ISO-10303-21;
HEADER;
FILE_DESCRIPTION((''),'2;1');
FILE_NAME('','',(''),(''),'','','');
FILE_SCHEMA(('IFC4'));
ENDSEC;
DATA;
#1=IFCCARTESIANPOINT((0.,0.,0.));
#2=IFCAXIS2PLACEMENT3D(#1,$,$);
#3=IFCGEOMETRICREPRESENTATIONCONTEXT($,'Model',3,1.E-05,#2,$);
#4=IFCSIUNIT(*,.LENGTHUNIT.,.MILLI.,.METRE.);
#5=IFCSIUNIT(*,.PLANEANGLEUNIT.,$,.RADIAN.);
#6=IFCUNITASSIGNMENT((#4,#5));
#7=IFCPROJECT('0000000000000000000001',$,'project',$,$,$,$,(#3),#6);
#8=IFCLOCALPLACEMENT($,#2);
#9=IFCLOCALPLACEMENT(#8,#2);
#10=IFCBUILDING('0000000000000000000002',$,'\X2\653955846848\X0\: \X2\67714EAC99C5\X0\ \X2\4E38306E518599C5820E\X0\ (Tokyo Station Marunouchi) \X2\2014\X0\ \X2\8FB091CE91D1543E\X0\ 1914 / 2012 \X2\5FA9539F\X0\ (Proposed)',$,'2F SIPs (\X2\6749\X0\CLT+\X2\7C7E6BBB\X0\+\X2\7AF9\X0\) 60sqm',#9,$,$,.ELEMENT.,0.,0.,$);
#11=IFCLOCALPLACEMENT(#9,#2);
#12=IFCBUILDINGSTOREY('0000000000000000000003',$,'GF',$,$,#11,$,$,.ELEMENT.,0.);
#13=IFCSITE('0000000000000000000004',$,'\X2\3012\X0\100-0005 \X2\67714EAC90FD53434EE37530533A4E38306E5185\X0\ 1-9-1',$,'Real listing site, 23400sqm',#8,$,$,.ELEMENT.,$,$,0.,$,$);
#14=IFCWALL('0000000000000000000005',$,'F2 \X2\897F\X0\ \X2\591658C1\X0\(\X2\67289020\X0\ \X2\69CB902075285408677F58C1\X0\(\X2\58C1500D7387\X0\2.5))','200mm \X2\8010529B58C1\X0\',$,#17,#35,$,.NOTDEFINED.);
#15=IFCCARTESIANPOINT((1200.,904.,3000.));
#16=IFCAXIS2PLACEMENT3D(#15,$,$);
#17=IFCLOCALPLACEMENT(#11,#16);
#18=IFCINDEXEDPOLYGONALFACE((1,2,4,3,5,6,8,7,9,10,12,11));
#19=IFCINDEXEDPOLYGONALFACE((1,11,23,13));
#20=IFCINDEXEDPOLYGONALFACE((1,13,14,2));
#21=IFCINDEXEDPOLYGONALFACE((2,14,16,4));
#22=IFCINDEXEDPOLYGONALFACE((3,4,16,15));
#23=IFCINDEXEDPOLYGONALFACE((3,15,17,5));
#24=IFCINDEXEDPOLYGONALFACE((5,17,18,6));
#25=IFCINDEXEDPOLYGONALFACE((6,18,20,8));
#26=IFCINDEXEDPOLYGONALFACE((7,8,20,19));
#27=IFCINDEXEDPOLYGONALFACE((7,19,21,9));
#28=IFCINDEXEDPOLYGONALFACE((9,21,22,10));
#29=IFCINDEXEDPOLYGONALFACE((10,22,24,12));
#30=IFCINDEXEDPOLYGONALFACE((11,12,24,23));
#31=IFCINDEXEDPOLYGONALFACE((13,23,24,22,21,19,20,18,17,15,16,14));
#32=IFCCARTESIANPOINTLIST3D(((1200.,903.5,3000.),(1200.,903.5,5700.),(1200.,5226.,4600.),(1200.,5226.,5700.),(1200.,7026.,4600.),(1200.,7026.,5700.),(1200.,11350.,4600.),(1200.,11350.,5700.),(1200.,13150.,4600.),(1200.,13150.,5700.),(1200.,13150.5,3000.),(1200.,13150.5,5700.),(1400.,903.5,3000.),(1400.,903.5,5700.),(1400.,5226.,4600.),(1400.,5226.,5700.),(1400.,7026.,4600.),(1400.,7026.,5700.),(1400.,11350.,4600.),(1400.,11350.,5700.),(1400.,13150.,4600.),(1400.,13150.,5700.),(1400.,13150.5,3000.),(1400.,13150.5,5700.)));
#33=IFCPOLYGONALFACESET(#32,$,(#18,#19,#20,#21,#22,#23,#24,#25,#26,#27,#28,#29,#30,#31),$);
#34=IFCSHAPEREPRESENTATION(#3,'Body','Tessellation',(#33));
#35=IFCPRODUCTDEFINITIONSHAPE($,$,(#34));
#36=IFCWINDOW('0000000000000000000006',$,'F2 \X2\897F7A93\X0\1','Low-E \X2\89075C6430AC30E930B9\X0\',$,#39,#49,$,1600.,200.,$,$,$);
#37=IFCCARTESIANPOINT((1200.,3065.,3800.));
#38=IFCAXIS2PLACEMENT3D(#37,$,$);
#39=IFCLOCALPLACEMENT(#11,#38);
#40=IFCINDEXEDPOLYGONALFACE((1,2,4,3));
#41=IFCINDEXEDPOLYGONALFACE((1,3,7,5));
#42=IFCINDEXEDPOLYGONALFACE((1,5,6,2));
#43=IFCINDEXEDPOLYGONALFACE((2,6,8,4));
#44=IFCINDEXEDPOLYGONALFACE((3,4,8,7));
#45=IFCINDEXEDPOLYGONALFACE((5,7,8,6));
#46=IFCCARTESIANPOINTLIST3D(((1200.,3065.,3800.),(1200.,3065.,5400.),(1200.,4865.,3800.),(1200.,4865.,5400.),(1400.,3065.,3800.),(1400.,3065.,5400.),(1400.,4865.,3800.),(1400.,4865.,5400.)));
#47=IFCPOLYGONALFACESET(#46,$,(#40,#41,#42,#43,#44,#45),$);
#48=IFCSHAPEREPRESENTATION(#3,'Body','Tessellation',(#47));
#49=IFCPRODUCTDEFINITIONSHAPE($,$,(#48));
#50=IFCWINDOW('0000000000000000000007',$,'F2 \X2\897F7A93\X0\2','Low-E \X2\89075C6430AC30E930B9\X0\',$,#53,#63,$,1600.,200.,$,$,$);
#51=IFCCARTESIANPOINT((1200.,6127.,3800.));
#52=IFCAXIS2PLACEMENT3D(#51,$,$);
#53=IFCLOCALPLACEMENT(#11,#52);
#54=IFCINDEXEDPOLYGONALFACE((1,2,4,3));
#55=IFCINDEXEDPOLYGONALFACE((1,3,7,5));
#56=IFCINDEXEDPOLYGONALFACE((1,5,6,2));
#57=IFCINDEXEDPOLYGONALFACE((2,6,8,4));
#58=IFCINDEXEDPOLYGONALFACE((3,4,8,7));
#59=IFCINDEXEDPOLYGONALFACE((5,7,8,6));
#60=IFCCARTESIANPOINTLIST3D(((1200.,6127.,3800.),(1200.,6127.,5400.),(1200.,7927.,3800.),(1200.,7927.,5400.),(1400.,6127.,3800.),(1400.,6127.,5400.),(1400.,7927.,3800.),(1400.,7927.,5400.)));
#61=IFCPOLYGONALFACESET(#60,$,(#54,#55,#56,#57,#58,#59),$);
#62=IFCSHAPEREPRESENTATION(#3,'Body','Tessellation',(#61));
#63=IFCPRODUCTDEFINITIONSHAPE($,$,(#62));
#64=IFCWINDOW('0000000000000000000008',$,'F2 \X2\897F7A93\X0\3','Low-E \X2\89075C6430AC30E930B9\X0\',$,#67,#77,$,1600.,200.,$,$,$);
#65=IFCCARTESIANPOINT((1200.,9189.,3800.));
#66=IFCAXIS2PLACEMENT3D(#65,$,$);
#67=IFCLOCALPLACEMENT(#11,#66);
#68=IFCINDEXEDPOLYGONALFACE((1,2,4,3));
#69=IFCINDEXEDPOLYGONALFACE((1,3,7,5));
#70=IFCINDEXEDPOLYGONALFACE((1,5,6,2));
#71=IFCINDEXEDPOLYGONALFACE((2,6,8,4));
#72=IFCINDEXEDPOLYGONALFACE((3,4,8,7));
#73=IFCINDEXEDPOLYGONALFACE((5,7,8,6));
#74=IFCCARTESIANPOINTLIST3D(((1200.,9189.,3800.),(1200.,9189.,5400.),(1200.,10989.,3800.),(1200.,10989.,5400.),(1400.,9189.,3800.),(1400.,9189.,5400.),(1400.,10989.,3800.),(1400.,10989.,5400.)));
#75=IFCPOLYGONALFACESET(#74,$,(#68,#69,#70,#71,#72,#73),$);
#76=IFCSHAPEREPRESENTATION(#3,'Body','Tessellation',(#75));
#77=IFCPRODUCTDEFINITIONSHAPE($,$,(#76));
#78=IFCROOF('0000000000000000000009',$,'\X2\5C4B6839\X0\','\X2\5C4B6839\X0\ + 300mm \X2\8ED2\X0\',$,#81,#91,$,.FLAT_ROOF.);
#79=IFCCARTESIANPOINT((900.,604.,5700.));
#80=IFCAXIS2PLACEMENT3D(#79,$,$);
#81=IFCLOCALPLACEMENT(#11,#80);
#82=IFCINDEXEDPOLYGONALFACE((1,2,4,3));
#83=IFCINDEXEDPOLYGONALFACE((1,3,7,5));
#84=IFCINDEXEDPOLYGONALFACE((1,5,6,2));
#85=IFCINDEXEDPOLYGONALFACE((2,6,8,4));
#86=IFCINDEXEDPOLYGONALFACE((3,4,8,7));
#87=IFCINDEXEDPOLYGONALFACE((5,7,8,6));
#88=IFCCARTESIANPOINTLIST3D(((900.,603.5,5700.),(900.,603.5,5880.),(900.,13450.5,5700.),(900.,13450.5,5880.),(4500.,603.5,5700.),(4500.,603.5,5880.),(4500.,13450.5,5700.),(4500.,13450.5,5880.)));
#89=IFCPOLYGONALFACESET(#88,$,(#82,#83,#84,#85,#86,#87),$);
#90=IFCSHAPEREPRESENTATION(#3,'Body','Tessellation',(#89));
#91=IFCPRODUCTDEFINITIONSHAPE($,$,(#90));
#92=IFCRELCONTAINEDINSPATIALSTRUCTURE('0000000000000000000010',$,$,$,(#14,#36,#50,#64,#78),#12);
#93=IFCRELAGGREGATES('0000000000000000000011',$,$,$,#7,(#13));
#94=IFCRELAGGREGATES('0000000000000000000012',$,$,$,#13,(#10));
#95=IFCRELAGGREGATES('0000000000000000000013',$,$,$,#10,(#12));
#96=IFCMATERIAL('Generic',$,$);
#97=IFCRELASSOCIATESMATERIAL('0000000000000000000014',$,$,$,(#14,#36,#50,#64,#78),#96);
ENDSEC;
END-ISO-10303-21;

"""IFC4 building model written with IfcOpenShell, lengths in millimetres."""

from ifc_helpers import new_model, si_unit, frame, frame_2d, origin, place, context, project, spatial, rectangle, extrude, material, element, fill, save


model = new_model("IFC4")

# Units and contexts
model_context = context("Model", 3, precision=1e-05, world=origin())
ifc_project = project(units=[si_unit("LENGTHUNIT", "METRE", prefix="MILLI"), si_unit("PLANEANGLEUNIT", "RADIAN")], contexts=[model_context])

# Site, building, storey
site_placement = place(None, origin())
site = spatial("IfcSite", under=ifc_project, at=site_placement, Name="〒100-0005 東京都千代田区丸の内 1-9-1", ObjectType="Real listing site, 23400sqm", CompositionType="ELEMENT", RefElevation=0.0)
building_placement = place(site_placement, origin())
building = spatial("IfcBuilding", under=site, at=building_placement, Name="改善案: 東京駅 丸の内駅舎 (Tokyo Station Marunouchi) — 辰野金吾 1914 / 2012 復原 (Proposed)", ObjectType="2F SIPs (杉CLT+籾殻+竹) 60sqm", CompositionType="ELEMENT", ElevationOfRefHeight=0.0, ElevationOfTerrain=0.0)
storey_placement = place(building_placement, origin())
storey = spatial("IfcBuildingStorey", under=building, at=storey_placement, Name="GF", CompositionType="ELEMENT", Elevation=0.0)

# Shared definitions
ifc_material = material(Name="Generic")

# Wall, openings, windows
wall_1_placement = place(storey_placement, frame((1200.0, 904.0, 3000.0)))
wall_1 = element("IfcWall", 1, at=wall_1_placement, inside=storey, material=ifc_material, Name="F2 西 外壁(木造 構造用合板壁(壁倍率2.5))", Description="200mm 耐力壁", PredefinedType="NOTDEFINED", context=model_context, shape_type="SweptSolid", body=[
    extrude(rectangle(XDim=200.0, YDim=12247.0, at=frame_2d((100.0, 6123.0))), frame((1200.0, 904.0, 3000.0)), (0.0, 0.0, 1.0), 2700.0),
])
opening_1_placement = place(storey_placement, frame((1200.0, 3065.0, 3800.0)))
opening_1 = element("IfcOpeningElement", 2, at=opening_1_placement, cuts=wall_1, PredefinedType="NOTDEFINED", context=model_context, shape_type="SweptSolid", body=[
    extrude(rectangle(XDim=200.0, YDim=1800.0, at=frame_2d((100.0, 900.0))), frame((1200.0, 3065.0, 3800.0)), (0.0, 0.0, 1.0), 1600.0),
])
opening_2_placement = place(storey_placement, frame((1200.0, 6127.0, 3800.0)))
opening_2 = element("IfcOpeningElement", 3, at=opening_2_placement, cuts=wall_1, PredefinedType="NOTDEFINED", context=model_context, shape_type="SweptSolid", body=[
    extrude(rectangle(XDim=200.0, YDim=1800.0, at=frame_2d((100.0, 900.0))), frame((1200.0, 6127.0, 3800.0)), (0.0, 0.0, 1.0), 1600.0),
])
opening_3_placement = place(storey_placement, frame((1200.0, 9189.0, 3800.0)))
opening_3 = element("IfcOpeningElement", 4, at=opening_3_placement, cuts=wall_1, PredefinedType="NOTDEFINED", context=model_context, shape_type="SweptSolid", body=[
    extrude(rectangle(XDim=200.0, YDim=1800.0, at=frame_2d((100.0, 900.0))), frame((1200.0, 9189.0, 3800.0)), (0.0, 0.0, 1.0), 1600.0),
])
window_1_placement = place(storey_placement, frame((1200.0, 3065.0, 3800.0)))
window_1 = element("IfcWindow", 5, at=window_1_placement, inside=storey, material=ifc_material, Name="F2 西窓1", Description="Low-E 複層ガラス", OverallHeight=1600.0, OverallWidth=200.0, context=model_context, shape_type="SweptSolid", body=[
    extrude(rectangle(XDim=200.0, YDim=1800.0, at=frame_2d((100.0, 900.0))), frame((1200.0, 3065.0, 3800.0)), (0.0, 0.0, 1.0), 1600.0),
])
fill(opening_1, window_1)
window_2_placement = place(storey_placement, frame((1200.0, 6127.0, 3800.0)))
window_2 = element("IfcWindow", 6, at=window_2_placement, inside=storey, material=ifc_material, Name="F2 西窓2", Description="Low-E 複層ガラス", OverallHeight=1600.0, OverallWidth=200.0, context=model_context, shape_type="SweptSolid", body=[
    extrude(rectangle(XDim=200.0, YDim=1800.0, at=frame_2d((100.0, 900.0))), frame((1200.0, 6127.0, 3800.0)), (0.0, 0.0, 1.0), 1600.0),
])
fill(opening_2, window_2)
window_3_placement = place(storey_placement, frame((1200.0, 9189.0, 3800.0)))
window_3 = element("IfcWindow", 7, at=window_3_placement, inside=storey, material=ifc_material, Name="F2 西窓3", Description="Low-E 複層ガラス", OverallHeight=1600.0, OverallWidth=200.0, context=model_context, shape_type="SweptSolid", body=[
    extrude(rectangle(XDim=200.0, YDim=1800.0, at=frame_2d((100.0, 900.0))), frame((1200.0, 9189.0, 3800.0)), (0.0, 0.0, 1.0), 1600.0),
])
fill(opening_3, window_3)

# Roof
roof_placement = place(storey_placement, frame((900.0, 604.0, 5700.0)))
element("IfcRoof", 8, at=roof_placement, inside=storey, material=ifc_material, Name="屋根", Description="屋根 + 300mm 軒", PredefinedType="FLAT_ROOF", context=model_context, shape_type="SweptSolid", body=[
    extrude(rectangle(XDim=3600.0, YDim=12847.0, at=frame_2d((1800.0, 6423.0))), frame((900.0, 604.0, 5700.0)), (0.0, 0.0, 1.0), 180.0),
])

save(model, "model.ifc")
